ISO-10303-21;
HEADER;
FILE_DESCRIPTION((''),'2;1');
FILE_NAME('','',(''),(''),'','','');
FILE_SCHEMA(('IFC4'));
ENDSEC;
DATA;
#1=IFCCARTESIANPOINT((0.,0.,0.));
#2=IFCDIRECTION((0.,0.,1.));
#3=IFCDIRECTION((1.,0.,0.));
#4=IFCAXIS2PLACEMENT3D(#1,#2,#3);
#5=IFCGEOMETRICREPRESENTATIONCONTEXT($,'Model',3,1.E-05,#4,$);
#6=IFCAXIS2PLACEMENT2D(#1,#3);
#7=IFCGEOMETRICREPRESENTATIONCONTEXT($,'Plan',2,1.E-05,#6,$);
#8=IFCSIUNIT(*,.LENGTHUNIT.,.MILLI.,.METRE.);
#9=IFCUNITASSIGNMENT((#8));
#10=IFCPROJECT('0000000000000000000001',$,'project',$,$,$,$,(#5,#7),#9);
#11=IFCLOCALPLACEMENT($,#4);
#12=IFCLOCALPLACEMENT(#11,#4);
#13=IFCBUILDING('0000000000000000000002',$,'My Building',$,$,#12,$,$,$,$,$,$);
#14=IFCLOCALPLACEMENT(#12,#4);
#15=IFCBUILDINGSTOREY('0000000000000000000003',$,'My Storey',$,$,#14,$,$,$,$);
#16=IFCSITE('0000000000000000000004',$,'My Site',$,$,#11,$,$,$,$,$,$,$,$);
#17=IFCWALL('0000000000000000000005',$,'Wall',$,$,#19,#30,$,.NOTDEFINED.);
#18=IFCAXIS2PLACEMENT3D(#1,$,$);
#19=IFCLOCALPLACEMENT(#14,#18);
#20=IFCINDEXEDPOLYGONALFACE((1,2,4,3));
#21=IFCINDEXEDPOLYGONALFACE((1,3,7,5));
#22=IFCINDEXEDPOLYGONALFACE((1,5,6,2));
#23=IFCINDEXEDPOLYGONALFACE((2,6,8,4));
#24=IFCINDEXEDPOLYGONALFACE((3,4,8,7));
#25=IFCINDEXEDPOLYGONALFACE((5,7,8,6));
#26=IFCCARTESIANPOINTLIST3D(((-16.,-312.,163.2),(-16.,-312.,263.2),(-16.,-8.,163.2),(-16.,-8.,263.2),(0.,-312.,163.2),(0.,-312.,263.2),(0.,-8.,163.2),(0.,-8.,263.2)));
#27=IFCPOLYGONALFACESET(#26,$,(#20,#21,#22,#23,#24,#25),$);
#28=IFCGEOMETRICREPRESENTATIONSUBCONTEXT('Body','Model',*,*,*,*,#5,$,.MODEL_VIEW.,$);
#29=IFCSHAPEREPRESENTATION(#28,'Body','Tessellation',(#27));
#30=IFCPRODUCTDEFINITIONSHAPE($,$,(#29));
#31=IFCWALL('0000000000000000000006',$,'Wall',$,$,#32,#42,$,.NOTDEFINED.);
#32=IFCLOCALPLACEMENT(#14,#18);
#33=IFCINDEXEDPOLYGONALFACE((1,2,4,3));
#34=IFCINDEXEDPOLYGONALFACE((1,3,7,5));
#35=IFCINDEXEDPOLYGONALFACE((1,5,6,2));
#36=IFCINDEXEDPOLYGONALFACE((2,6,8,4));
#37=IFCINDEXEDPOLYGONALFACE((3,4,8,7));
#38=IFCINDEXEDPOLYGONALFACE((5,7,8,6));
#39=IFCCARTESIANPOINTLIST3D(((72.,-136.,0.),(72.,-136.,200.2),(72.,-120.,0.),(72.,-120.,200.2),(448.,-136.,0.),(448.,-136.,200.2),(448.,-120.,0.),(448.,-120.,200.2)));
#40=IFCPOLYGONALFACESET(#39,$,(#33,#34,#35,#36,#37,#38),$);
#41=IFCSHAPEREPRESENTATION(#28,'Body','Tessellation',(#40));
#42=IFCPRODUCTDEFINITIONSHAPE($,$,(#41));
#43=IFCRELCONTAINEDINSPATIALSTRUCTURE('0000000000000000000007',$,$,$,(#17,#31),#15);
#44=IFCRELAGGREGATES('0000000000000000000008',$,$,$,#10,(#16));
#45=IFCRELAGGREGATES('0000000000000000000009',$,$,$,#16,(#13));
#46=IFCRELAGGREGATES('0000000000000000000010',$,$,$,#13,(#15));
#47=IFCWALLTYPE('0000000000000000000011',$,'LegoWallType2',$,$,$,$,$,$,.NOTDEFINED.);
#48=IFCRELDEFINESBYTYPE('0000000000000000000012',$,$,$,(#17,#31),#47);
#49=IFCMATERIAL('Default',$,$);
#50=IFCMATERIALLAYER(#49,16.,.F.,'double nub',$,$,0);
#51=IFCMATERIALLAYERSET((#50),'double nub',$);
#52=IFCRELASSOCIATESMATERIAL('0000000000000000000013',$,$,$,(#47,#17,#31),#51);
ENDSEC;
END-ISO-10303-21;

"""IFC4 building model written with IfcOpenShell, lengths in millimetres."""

from ifc_helpers import new_model, si_unit, frame, frame_2d, origin_with_axes, place, context, subcontext, project, spatial, indexed_curve, outline, extrude, material, layer, layer_set, layer_usage, type_object, element, save


model = new_model("IFC4")

# Units and contexts
model_context = context("Model", 3, precision=1e-05, world=origin_with_axes())
plan_context = context("Plan", 2, precision=1e-05, world=frame_2d((0.0, 0.0, 0.0), x_axis=(1.0, 0.0, 0.0)))
body_context = subcontext(model_context, "Body", "Model", "MODEL_VIEW")
ifc_project = project(units=[si_unit("LENGTHUNIT", "METRE", prefix="MILLI")], contexts=[model_context, plan_context])

# Site, building, storey
site_placement = place(None, origin_with_axes())
site = spatial("IfcSite", under=ifc_project, at=site_placement, Name="My Site")
building_placement = place(site_placement, origin_with_axes())
building = spatial("IfcBuilding", under=site, at=building_placement, Name="My Building")
storey_placement = place(building_placement, origin_with_axes())
storey = spatial("IfcBuildingStorey", under=building, at=storey_placement, Name="My Storey")

# Walls
ifc_material = material(Name="Default")
ifc_layer = layer(ifc_material, 16.0, ventilated=False, Name="double nub", Priority=0)
ifc_layer_set = layer_set([ifc_layer], Name="double nub")
ifc_layer_usage_1 = layer_usage(ifc_layer_set, "AXIS2", "POSITIVE", 0.0)
wall_type = type_object("IfcWallType", Name="LegoWallType2", PredefinedType="NOTDEFINED", material=ifc_layer_set)
wall_1_placement = place(storey_placement, frame((0.0, -312.0, 163.2), z_axis=(0.0, 0.0, 1.0), x_axis=(0.0, 1.0, 0.0)))
element("IfcWall", 1, at=wall_1_placement, inside=storey, type_object=wall_type, material=ifc_layer_usage_1, Name="Wall", PredefinedType="NOTDEFINED", context=body_context, shape_type="SweptSolid", body=[
    extrude(outline(indexed_curve([(0.0, 0.0), (0.0, 16.0), (304.0, 16.0), (304.0, 0.0), (0.0, 0.0)], self_intersect=False)), origin_with_axes(), (0.0, 0.0, 1.0), 100.0),
])
ifc_layer_usage_2 = layer_usage(ifc_layer_set, "AXIS2", "POSITIVE", 0.0)
wall_2_placement = place(storey_placement, frame((72.0, -136.0, 0.0), z_axis=(0.0, 0.0, 1.0), x_axis=(1.0, 0.0, 0.0)))
element("IfcWall", 2, at=wall_2_placement, inside=storey, type_object=wall_type, material=ifc_layer_usage_2, Name="Wall", PredefinedType="NOTDEFINED", context=body_context, shape_type="SweptSolid", body=[
    extrude(outline(indexed_curve([(0.0, 0.0), (0.0, 16.0), (376.0, 16.0), (376.0, 0.0), (0.0, 0.0)], self_intersect=False)), origin_with_axes(), (0.0, 0.0, 1.0), 200.2),
])

save(model, "model.ifc")
